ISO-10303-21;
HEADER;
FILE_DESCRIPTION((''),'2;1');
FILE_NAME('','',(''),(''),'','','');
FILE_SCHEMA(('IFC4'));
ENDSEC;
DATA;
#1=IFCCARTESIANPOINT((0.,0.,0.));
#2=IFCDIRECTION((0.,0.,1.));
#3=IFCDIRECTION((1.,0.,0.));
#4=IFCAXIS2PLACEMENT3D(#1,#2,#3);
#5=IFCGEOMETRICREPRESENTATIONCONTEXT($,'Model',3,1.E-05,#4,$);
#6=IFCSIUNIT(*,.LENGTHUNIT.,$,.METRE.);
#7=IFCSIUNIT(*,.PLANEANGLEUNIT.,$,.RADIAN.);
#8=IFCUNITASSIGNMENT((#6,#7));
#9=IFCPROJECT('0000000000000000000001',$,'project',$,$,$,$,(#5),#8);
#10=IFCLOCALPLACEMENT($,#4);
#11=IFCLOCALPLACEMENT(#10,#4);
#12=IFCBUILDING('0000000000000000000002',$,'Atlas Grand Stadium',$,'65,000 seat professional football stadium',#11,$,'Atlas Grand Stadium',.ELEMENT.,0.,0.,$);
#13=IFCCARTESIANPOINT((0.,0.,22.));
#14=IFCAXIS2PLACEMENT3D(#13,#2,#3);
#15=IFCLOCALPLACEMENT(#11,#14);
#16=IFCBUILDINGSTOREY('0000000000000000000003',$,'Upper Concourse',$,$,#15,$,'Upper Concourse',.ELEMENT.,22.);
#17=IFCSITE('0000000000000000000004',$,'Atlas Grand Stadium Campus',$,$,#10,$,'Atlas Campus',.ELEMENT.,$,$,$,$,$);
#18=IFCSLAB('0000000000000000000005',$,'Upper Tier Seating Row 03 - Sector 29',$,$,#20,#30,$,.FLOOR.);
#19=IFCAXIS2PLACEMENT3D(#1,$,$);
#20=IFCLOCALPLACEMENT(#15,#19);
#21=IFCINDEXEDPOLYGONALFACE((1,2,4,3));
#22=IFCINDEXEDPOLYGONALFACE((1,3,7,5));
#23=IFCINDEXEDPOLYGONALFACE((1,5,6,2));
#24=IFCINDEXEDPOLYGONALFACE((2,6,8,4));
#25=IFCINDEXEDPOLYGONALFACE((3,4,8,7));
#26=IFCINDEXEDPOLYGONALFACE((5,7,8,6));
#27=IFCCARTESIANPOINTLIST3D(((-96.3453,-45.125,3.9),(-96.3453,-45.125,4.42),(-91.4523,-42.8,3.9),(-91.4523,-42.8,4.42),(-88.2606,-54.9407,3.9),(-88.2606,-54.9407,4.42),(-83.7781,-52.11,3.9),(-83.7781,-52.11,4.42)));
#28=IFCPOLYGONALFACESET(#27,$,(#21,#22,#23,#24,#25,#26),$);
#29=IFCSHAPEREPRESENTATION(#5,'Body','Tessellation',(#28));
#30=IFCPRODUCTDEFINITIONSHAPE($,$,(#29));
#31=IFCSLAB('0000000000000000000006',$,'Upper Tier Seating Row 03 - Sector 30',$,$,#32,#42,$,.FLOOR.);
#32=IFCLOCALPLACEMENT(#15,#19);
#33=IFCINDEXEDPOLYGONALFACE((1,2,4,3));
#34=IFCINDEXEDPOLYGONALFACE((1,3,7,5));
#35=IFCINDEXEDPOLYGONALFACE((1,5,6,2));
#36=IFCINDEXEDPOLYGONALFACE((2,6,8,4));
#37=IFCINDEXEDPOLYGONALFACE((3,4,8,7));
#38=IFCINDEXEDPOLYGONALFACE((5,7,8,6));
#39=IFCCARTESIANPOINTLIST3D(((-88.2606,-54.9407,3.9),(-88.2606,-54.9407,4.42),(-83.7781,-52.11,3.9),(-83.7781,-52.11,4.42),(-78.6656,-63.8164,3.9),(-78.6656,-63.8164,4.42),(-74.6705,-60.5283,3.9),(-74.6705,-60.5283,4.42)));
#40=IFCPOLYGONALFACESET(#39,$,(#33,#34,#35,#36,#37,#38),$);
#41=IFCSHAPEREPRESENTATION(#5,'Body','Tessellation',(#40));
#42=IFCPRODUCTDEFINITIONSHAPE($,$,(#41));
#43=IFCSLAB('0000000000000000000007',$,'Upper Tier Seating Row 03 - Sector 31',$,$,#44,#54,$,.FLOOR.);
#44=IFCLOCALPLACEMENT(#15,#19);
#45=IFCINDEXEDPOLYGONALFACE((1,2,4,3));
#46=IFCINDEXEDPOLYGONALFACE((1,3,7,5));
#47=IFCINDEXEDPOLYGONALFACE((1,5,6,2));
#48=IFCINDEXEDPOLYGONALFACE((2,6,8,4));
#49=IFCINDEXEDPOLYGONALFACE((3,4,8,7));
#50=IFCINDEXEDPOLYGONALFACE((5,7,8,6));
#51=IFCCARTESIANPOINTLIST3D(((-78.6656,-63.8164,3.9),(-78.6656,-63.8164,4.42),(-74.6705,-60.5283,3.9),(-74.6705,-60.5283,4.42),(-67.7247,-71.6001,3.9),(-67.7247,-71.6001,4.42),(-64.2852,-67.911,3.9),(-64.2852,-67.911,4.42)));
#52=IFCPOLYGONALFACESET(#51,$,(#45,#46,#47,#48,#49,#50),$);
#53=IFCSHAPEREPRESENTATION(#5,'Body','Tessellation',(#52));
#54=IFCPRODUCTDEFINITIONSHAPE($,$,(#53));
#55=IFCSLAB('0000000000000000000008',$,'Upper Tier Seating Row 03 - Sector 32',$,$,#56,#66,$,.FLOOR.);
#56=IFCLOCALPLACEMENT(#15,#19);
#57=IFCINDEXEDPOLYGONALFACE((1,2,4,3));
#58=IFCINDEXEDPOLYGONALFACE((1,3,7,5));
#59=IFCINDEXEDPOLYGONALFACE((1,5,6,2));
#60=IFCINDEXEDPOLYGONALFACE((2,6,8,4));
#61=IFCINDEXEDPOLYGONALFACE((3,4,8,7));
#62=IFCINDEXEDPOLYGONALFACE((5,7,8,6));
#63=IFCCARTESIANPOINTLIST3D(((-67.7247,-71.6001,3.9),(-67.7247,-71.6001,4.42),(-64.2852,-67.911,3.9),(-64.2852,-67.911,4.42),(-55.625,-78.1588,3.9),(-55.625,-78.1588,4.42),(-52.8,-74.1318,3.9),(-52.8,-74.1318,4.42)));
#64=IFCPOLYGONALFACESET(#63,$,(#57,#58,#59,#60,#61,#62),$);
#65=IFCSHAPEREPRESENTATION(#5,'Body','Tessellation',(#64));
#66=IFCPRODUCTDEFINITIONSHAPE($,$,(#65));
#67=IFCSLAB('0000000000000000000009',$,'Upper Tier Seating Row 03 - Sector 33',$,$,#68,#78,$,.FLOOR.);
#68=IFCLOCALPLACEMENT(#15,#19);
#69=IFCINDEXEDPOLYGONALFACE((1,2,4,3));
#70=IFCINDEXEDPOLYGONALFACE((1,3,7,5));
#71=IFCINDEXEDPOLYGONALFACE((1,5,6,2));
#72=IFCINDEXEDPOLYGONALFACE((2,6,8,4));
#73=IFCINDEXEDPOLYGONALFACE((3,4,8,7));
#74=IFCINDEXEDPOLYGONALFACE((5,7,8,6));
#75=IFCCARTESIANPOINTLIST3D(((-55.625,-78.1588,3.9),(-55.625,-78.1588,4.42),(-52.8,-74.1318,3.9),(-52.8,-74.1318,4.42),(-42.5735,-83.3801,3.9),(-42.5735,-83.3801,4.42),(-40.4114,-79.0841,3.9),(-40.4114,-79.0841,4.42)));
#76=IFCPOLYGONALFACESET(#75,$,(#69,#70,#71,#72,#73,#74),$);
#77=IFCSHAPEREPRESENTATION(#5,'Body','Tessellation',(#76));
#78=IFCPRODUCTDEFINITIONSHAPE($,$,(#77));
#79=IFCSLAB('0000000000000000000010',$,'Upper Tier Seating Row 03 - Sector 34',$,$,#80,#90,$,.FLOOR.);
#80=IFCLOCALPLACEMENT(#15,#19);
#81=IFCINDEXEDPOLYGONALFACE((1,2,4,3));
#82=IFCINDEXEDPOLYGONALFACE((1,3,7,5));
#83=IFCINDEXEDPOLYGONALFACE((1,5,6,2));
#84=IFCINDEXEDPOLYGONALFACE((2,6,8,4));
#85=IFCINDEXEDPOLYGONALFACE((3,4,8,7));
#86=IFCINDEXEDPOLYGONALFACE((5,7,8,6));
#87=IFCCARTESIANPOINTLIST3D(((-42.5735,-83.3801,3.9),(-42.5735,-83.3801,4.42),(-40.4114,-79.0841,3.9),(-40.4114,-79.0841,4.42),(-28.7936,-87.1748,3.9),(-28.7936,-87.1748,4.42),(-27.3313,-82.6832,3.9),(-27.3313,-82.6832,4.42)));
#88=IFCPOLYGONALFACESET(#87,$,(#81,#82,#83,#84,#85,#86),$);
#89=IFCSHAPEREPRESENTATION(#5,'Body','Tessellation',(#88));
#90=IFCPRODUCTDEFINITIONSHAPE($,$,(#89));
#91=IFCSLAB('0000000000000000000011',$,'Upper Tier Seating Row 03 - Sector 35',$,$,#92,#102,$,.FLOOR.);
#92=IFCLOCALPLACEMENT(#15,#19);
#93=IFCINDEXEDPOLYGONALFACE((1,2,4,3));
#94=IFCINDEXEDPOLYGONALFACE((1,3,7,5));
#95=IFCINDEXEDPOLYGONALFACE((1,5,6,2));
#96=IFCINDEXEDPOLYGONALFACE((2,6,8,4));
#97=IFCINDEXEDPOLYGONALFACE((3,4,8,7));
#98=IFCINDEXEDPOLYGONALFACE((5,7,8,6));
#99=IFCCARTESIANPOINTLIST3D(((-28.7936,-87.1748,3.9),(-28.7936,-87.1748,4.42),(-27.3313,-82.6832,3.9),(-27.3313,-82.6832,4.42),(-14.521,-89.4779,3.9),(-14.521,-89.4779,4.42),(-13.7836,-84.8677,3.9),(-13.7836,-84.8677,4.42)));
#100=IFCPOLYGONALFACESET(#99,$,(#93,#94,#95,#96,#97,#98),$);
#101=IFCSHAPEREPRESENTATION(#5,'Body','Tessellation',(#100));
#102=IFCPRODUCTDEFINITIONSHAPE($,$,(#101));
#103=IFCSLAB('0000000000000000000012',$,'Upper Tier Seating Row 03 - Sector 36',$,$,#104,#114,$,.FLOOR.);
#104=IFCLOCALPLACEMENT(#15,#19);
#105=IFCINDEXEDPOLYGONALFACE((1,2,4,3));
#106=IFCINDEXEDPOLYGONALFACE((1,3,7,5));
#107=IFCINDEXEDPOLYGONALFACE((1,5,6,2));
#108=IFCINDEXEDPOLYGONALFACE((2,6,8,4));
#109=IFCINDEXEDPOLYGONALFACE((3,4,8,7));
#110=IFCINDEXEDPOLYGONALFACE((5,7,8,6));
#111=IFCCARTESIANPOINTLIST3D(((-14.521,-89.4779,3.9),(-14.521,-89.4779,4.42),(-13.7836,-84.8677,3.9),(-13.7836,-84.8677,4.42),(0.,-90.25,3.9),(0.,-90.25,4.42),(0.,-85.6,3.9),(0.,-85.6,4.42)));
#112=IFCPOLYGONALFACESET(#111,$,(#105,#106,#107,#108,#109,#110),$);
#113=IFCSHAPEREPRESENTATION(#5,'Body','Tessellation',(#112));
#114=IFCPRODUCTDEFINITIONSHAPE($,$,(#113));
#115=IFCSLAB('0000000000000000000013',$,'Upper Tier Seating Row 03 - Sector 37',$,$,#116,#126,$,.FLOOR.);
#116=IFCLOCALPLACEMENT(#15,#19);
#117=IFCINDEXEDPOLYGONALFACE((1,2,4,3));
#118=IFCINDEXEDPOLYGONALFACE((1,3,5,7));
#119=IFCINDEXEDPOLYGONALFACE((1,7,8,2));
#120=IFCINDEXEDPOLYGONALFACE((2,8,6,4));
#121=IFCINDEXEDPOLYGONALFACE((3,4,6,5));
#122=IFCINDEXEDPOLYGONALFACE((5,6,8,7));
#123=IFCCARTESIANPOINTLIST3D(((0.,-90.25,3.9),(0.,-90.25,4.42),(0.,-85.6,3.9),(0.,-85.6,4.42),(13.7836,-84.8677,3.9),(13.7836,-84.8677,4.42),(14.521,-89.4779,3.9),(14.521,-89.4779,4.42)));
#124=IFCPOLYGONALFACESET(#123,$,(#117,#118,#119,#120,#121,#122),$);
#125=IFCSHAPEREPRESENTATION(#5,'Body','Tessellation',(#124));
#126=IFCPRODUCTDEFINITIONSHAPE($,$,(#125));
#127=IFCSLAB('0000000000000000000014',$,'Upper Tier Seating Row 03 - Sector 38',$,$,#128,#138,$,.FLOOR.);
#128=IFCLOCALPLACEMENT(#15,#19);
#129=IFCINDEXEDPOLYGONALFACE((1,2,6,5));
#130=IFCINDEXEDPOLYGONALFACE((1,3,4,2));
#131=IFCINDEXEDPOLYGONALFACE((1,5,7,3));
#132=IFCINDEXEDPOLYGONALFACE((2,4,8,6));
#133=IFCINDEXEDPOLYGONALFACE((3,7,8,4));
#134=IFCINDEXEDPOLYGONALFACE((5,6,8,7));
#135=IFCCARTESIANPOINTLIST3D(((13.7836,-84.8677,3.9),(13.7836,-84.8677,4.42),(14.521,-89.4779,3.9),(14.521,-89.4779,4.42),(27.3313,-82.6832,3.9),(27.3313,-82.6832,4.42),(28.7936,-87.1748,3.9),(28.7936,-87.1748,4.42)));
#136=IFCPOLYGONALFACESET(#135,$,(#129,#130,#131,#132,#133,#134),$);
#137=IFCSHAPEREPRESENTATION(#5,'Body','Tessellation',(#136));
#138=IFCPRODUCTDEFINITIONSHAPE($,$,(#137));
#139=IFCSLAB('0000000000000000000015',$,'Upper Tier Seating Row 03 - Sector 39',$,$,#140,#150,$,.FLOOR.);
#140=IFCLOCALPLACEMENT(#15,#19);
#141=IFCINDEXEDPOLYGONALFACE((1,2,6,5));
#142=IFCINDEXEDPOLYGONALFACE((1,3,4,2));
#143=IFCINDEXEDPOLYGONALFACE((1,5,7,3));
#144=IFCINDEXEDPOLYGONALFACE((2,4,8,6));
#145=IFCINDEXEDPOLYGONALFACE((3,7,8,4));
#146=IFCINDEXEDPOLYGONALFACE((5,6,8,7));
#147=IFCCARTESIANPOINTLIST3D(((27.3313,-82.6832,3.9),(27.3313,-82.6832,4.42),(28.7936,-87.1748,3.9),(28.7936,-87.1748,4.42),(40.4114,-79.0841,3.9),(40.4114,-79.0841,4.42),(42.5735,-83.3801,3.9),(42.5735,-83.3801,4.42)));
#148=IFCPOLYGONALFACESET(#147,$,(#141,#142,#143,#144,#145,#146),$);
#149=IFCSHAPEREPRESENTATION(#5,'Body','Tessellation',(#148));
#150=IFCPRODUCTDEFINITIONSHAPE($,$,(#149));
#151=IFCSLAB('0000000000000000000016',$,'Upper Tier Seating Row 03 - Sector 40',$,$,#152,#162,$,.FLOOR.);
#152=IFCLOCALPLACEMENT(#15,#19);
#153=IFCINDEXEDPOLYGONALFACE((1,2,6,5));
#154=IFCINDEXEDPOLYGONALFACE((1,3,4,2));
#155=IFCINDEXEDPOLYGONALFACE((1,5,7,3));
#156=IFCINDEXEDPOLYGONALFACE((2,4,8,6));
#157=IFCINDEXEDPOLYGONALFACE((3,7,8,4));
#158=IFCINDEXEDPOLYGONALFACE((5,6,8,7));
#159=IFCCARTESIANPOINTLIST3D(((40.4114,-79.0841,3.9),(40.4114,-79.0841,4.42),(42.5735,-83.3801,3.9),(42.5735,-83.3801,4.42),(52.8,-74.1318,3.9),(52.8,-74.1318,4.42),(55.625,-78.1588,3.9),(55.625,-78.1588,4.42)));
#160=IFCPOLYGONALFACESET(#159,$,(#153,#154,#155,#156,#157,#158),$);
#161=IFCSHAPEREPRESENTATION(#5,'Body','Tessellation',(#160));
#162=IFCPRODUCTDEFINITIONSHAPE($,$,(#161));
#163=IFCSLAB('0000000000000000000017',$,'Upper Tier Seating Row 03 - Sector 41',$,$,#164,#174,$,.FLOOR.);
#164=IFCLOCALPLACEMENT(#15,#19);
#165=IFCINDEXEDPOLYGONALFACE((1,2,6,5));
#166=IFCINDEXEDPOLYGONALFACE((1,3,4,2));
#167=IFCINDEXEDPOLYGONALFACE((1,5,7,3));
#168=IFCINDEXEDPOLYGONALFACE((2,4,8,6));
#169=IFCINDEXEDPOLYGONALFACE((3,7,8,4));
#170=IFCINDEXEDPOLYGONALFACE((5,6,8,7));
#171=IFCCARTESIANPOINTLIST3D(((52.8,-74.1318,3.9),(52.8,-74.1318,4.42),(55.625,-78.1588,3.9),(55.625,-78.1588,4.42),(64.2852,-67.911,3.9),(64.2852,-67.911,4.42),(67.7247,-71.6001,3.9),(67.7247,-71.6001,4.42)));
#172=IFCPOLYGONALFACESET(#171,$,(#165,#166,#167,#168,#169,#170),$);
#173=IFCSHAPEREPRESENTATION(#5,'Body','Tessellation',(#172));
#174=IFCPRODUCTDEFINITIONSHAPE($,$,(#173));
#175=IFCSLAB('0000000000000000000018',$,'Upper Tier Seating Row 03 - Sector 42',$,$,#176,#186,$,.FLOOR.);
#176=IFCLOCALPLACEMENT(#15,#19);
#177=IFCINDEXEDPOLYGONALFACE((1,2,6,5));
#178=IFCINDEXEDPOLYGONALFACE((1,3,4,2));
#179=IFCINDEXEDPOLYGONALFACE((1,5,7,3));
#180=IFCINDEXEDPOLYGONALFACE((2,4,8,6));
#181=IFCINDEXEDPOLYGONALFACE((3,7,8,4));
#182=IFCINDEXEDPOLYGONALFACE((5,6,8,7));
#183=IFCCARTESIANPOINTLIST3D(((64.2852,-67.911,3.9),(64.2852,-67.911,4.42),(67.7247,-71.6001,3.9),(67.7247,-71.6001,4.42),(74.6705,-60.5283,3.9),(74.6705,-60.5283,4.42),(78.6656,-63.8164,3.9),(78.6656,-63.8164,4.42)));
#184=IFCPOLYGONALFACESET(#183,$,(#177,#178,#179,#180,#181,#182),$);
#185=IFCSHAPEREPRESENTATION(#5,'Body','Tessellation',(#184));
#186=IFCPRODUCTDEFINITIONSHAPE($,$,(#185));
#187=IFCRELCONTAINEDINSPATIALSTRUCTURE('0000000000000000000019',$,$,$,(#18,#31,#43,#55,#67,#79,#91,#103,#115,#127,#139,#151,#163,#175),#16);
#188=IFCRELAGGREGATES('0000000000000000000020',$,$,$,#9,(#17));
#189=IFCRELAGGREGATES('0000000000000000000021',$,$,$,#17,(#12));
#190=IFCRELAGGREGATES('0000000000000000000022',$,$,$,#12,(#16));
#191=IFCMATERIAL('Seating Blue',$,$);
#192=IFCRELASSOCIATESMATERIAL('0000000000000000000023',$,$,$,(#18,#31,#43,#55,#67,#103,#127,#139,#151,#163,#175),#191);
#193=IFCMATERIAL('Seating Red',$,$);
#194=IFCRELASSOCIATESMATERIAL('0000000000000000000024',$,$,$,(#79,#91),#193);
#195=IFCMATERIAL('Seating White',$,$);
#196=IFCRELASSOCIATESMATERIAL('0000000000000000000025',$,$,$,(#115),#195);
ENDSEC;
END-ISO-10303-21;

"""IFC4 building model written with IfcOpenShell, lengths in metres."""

from ifc_helpers import new_model, si_unit, frame, origin_with_axes, place, context, project, spatial, polyline, outline, extrude, material, element, save


model = new_model("IFC4")

# Units and contexts
model_context = context("Model", 3, precision=1e-05, world=origin_with_axes())
ifc_project = project(units=[si_unit("LENGTHUNIT", "METRE"), si_unit("PLANEANGLEUNIT", "RADIAN")], contexts=[model_context])

# Site, building, storey
site_placement = place(None, origin_with_axes())
site = spatial("IfcSite", under=ifc_project, at=site_placement, Name="Atlas Grand Stadium Campus", LongName="Atlas Campus", CompositionType="ELEMENT")
building_placement = place(site_placement, origin_with_axes())
building = spatial("IfcBuilding", under=site, at=building_placement, Name="Atlas Grand Stadium", ObjectType="65,000 seat professional football stadium", LongName="Atlas Grand Stadium", CompositionType="ELEMENT", ElevationOfRefHeight=0.0, ElevationOfTerrain=0.0)
storey_placement = place(building_placement, frame((0.0, 0.0, 22.0), z_axis=(0.0, 0.0, 1.0), x_axis=(1.0, 0.0, 0.0)))
storey = spatial("IfcBuildingStorey", under=building, at=storey_placement, Name="Upper Concourse", LongName="Upper Concourse", CompositionType="ELEMENT", Elevation=22.0)

# Slabs
ifc_material_1 = material(Name="Seating Blue")
slab_1_placement = place(storey_placement, frame((0.0, 0.0, 3.9), z_axis=(0.0, 0.0, 1.0), x_axis=(1.0, 0.0, 0.0)))
element("IfcSlab", 1, at=slab_1_placement, inside=storey, material=ifc_material_1, Name="Upper Tier Seating Row 03 - Sector 29", PredefinedType="FLOOR", context=model_context, shape_type="SweptSolid", body=[
    extrude(outline(polyline([(-96.3453, -45.125), (-88.2606, -54.9407), (-83.7781, -52.11), (-91.4523, -42.8), (-96.3453, -45.125)])), origin_with_axes(), (0.0, 0.0, 1.0), 0.52),
])
slab_2_placement = place(storey_placement, frame((0.0, 0.0, 3.9), z_axis=(0.0, 0.0, 1.0), x_axis=(1.0, 0.0, 0.0)))
element("IfcSlab", 2, at=slab_2_placement, inside=storey, material=ifc_material_1, Name="Upper Tier Seating Row 03 - Sector 30", PredefinedType="FLOOR", context=model_context, shape_type="SweptSolid", body=[
    extrude(outline(polyline([(-88.2606, -54.9407), (-78.6656, -63.8164), (-74.6705, -60.5283), (-83.7781, -52.11), (-88.2606, -54.9407)])), origin_with_axes(), (0.0, 0.0, 1.0), 0.52),
])
slab_3_placement = place(storey_placement, frame((0.0, 0.0, 3.9), z_axis=(0.0, 0.0, 1.0), x_axis=(1.0, 0.0, 0.0)))
element("IfcSlab", 3, at=slab_3_placement, inside=storey, material=ifc_material_1, Name="Upper Tier Seating Row 03 - Sector 31", PredefinedType="FLOOR", context=model_context, shape_type="SweptSolid", body=[
    extrude(outline(polyline([(-78.6656, -63.8164), (-67.7247, -71.6001), (-64.2852, -67.9111), (-74.6705, -60.5283), (-78.6656, -63.8164)])), origin_with_axes(), (0.0, 0.0, 1.0), 0.52),
])
slab_4_placement = place(storey_placement, frame((0.0, 0.0, 3.9), z_axis=(0.0, 0.0, 1.0), x_axis=(1.0, 0.0, 0.0)))
element("IfcSlab", 4, at=slab_4_placement, inside=storey, material=ifc_material_1, Name="Upper Tier Seating Row 03 - Sector 32", PredefinedType="FLOOR", context=model_context, shape_type="SweptSolid", body=[
    extrude(outline(polyline([(-67.7247, -71.6001), (-55.625, -78.1588), (-52.8, -74.1318), (-64.2852, -67.9111), (-67.7247, -71.6001)])), origin_with_axes(), (0.0, 0.0, 1.0), 0.52),
])
slab_5_placement = place(storey_placement, frame((0.0, 0.0, 3.9), z_axis=(0.0, 0.0, 1.0), x_axis=(1.0, 0.0, 0.0)))
element("IfcSlab", 5, at=slab_5_placement, inside=storey, material=ifc_material_1, Name="Upper Tier Seating Row 03 - Sector 33", PredefinedType="FLOOR", context=model_context, shape_type="SweptSolid", body=[
    extrude(outline(polyline([(-55.625, -78.1588), (-42.5735, -83.3801), (-40.4114, -79.0841), (-52.8, -74.1318), (-55.625, -78.1588)])), origin_with_axes(), (0.0, 0.0, 1.0), 0.52),
])
ifc_material_2 = material(Name="Seating Red")
slab_6_placement = place(storey_placement, frame((0.0, 0.0, 3.9), z_axis=(0.0, 0.0, 1.0), x_axis=(1.0, 0.0, 0.0)))
element("IfcSlab", 6, at=slab_6_placement, inside=storey, material=ifc_material_2, Name="Upper Tier Seating Row 03 - Sector 34", PredefinedType="FLOOR", context=model_context, shape_type="SweptSolid", body=[
    extrude(outline(polyline([(-42.5735, -83.3801), (-28.7936, -87.1748), (-27.3313, -82.6833), (-40.4114, -79.0841), (-42.5735, -83.3801)])), origin_with_axes(), (0.0, 0.0, 1.0), 0.52),
])
slab_7_placement = place(storey_placement, frame((0.0, 0.0, 3.9), z_axis=(0.0, 0.0, 1.0), x_axis=(1.0, 0.0, 0.0)))
element("IfcSlab", 7, at=slab_7_placement, inside=storey, material=ifc_material_2, Name="Upper Tier Seating Row 03 - Sector 35", PredefinedType="FLOOR", context=model_context, shape_type="SweptSolid", body=[
    extrude(outline(polyline([(-28.7936, -87.1748), (-14.521, -89.4779), (-13.7836, -84.8677), (-27.3313, -82.6833), (-28.7936, -87.1748)])), origin_with_axes(), (0.0, 0.0, 1.0), 0.52),
])
slab_8_placement = place(storey_placement, frame((0.0, 0.0, 3.9), z_axis=(0.0, 0.0, 1.0), x_axis=(1.0, 0.0, 0.0)))
element("IfcSlab", 8, at=slab_8_placement, inside=storey, material=ifc_material_1, Name="Upper Tier Seating Row 03 - Sector 36", PredefinedType="FLOOR", context=model_context, shape_type="SweptSolid", body=[
    extrude(outline(polyline([(-14.521, -89.4779), (0.0, -90.25), (0.0, -85.6), (-13.7836, -84.8677), (-14.521, -89.4779)])), origin_with_axes(), (0.0, 0.0, 1.0), 0.52),
])
ifc_material_3 = material(Name="Seating White")
slab_9_placement = place(storey_placement, frame((0.0, 0.0, 3.9), z_axis=(0.0, 0.0, 1.0), x_axis=(1.0, 0.0, 0.0)))
element("IfcSlab", 9, at=slab_9_placement, inside=storey, material=ifc_material_3, Name="Upper Tier Seating Row 03 - Sector 37", PredefinedType="FLOOR", context=model_context, shape_type="SweptSolid", body=[
    extrude(outline(polyline([(0.0, -90.25), (14.521, -89.4779), (13.7836, -84.8677), (0.0, -85.6), (0.0, -90.25)])), origin_with_axes(), (0.0, 0.0, 1.0), 0.52),
])
slab_10_placement = place(storey_placement, frame((0.0, 0.0, 3.9), z_axis=(0.0, 0.0, 1.0), x_axis=(1.0, 0.0, 0.0)))
element("IfcSlab", 10, at=slab_10_placement, inside=storey, material=ifc_material_1, Name="Upper Tier Seating Row 03 - Sector 38", PredefinedType="FLOOR", context=model_context, shape_type="SweptSolid", body=[
    extrude(outline(polyline([(14.521, -89.4779), (28.7936, -87.1748), (27.3313, -82.6833), (13.7836, -84.8677), (14.521, -89.4779)])), origin_with_axes(), (0.0, 0.0, 1.0), 0.52),
])
slab_11_placement = place(storey_placement, frame((0.0, 0.0, 3.9), z_axis=(0.0, 0.0, 1.0), x_axis=(1.0, 0.0, 0.0)))
element("IfcSlab", 11, at=slab_11_placement, inside=storey, material=ifc_material_1, Name="Upper Tier Seating Row 03 - Sector 39", PredefinedType="FLOOR", context=model_context, shape_type="SweptSolid", body=[
    extrude(outline(polyline([(28.7936, -87.1748), (42.5735, -83.3801), (40.4114, -79.0841), (27.3313, -82.6833), (28.7936, -87.1748)])), origin_with_axes(), (0.0, 0.0, 1.0), 0.52),
])
slab_12_placement = place(storey_placement, frame((0.0, 0.0, 3.9), z_axis=(0.0, 0.0, 1.0), x_axis=(1.0, 0.0, 0.0)))
element("IfcSlab", 12, at=slab_12_placement, inside=storey, material=ifc_material_1, Name="Upper Tier Seating Row 03 - Sector 40", PredefinedType="FLOOR", context=model_context, shape_type="SweptSolid", body=[
    extrude(outline(polyline([(42.5735, -83.3801), (55.625, -78.1588), (52.8, -74.1318), (40.4114, -79.0841), (42.5735, -83.3801)])), origin_with_axes(), (0.0, 0.0, 1.0), 0.52),
])
slab_13_placement = place(storey_placement, frame((0.0, 0.0, 3.9), z_axis=(0.0, 0.0, 1.0), x_axis=(1.0, 0.0, 0.0)))
element("IfcSlab", 13, at=slab_13_placement, inside=storey, material=ifc_material_1, Name="Upper Tier Seating Row 03 - Sector 41", PredefinedType="FLOOR", context=model_context, shape_type="SweptSolid", body=[
    extrude(outline(polyline([(55.625, -78.1588), (67.7247, -71.6001), (64.2852, -67.9111), (52.8, -74.1318), (55.625, -78.1588)])), origin_with_axes(), (0.0, 0.0, 1.0), 0.52),
])
slab_14_placement = place(storey_placement, frame((0.0, 0.0, 3.9), z_axis=(0.0, 0.0, 1.0), x_axis=(1.0, 0.0, 0.0)))
element("IfcSlab", 14, at=slab_14_placement, inside=storey, material=ifc_material_1, Name="Upper Tier Seating Row 03 - Sector 42", PredefinedType="FLOOR", context=model_context, shape_type="SweptSolid", body=[
    extrude(outline(polyline([(67.7247, -71.6001), (78.6656, -63.8164), (74.6705, -60.5283), (64.2852, -67.9111), (67.7247, -71.6001)])), origin_with_axes(), (0.0, 0.0, 1.0), 0.52),
])

save(model, "model.ifc")
